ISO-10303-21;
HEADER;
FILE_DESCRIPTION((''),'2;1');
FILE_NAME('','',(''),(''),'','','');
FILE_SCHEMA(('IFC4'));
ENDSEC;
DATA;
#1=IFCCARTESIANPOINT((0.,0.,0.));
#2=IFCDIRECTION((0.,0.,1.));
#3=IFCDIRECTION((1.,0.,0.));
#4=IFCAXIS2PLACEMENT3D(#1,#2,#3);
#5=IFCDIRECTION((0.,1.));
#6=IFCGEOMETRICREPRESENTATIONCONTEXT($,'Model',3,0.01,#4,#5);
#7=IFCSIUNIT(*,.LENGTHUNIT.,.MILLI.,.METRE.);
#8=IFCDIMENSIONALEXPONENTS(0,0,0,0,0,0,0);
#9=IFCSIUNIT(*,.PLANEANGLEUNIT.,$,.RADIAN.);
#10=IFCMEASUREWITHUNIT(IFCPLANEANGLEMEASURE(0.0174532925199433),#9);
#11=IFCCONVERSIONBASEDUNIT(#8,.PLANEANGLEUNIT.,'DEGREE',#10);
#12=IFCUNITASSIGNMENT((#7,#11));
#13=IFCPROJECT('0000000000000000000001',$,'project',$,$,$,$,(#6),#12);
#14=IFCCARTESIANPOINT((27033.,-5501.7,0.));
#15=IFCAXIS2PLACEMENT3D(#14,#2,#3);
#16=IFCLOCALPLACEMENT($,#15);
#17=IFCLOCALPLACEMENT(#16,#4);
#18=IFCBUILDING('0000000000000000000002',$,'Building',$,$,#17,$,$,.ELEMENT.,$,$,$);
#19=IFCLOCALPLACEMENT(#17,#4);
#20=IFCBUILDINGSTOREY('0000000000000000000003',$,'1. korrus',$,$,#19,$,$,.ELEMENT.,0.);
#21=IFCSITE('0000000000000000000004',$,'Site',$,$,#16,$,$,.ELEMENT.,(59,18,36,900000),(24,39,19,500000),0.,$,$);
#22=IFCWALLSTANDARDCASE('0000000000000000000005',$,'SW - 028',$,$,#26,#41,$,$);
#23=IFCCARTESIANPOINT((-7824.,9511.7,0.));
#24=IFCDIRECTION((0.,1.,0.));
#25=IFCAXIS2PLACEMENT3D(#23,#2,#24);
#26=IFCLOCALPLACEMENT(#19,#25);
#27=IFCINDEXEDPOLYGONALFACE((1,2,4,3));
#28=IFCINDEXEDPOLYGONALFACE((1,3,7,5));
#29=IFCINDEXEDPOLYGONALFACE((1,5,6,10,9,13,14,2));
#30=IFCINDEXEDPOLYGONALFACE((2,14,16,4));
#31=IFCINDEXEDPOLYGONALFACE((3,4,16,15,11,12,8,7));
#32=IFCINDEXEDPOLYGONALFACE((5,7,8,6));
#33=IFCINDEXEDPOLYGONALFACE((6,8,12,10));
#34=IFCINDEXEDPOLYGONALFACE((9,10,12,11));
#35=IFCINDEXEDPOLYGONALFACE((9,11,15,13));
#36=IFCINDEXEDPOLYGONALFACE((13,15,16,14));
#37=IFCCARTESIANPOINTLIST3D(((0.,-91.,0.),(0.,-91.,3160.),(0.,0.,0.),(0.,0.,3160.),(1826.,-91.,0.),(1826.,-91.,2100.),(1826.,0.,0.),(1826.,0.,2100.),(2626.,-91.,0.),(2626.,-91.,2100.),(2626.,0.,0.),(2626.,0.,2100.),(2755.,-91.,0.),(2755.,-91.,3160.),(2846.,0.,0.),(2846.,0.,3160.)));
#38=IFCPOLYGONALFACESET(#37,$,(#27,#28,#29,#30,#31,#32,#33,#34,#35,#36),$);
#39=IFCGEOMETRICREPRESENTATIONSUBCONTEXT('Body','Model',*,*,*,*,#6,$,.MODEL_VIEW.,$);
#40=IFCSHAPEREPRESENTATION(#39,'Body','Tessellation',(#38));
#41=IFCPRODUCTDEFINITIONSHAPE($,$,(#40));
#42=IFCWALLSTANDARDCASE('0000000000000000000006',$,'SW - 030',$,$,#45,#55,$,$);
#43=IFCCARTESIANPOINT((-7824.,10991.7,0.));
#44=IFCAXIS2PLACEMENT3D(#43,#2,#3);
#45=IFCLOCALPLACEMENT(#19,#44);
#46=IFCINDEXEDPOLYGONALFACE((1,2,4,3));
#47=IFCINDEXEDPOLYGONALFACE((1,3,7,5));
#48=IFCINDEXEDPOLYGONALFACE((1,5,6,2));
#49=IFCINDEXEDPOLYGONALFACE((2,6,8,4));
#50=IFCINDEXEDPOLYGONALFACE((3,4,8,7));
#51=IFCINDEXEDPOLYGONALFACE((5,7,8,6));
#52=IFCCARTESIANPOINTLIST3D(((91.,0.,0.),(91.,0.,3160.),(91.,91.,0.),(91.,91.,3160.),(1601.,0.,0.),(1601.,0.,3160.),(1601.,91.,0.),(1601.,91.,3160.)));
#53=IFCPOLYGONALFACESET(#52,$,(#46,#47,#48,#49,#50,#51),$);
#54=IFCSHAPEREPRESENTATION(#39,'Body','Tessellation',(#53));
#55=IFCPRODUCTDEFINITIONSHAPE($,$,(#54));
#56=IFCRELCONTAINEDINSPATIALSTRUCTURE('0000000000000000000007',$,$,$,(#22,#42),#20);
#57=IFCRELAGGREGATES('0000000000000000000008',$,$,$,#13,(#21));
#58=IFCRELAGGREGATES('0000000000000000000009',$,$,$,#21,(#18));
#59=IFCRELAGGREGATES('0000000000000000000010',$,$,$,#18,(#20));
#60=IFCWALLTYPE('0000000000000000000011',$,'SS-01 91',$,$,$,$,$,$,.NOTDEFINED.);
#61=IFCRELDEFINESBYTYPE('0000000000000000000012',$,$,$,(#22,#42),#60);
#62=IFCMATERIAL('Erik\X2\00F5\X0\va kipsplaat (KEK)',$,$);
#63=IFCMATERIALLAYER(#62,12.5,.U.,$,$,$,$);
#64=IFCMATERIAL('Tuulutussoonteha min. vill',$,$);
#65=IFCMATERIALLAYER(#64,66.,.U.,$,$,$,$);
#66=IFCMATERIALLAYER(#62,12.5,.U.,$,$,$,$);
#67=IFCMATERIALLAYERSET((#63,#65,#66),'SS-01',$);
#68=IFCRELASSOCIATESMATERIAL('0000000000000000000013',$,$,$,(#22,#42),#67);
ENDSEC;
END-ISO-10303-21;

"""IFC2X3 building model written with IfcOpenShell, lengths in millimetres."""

from ifc_helpers import new_model, entity, si_unit, converted_unit, direction, frame, origin_with_axes, origin_2d_with_axis, place, context, subcontext, project, spatial, polyline, rectangle, outline, extrude, material, layer, layer_set, layer_usage, type_object, element, save


model = new_model("IFC2X3")

# Units and contexts
model_context = context("Model", 3, precision=0.01, world=origin_with_axes(), true_north=direction((0.0, 1.0)))
body_context = subcontext(model_context, "Body", "Model", "MODEL_VIEW")
ifc_project = project(units=[si_unit("LENGTHUNIT", "METRE", prefix="MILLI"), converted_unit("PLANEANGLEUNIT", "DEGREE", entity("IfcPlaneAngleMeasure", 0.0174532925199433), si_unit("PLANEANGLEUNIT", "RADIAN"), dimensions=[0, 0, 0, 0, 0, 0, 0])], contexts=[model_context])

# Site, building, storey
site_placement = place(None, frame((27033.0, -5501.7, 0.0), z_axis=(0.0, 0.0, 1.0), x_axis=(1.0, 0.0, 0.0)))
site = spatial("IfcSite", under=ifc_project, at=site_placement, Name="Site", CompositionType="ELEMENT", RefLatitude=(59, 18, 36, 900000), RefLongitude=(24, 39, 19, 500000), RefElevation=0.0)
building_placement = place(site_placement, origin_with_axes())
building = spatial("IfcBuilding", under=site, at=building_placement, Name="Building", CompositionType="ELEMENT")
storey_placement = place(building_placement, origin_with_axes())
storey = spatial("IfcBuildingStorey", under=building, at=storey_placement, Name="1. korrus", CompositionType="ELEMENT", Elevation=0.0)

# Wall, opening
ifc_material_1 = material(Name="Erikõva kipsplaat (KEK)")
ifc_layer_1 = layer(ifc_material_1, 12.5, ventilated="UNKNOWN")
ifc_material_2 = material(Name="Tuulutussoonteha min. vill")
ifc_layer_2 = layer(ifc_material_2, 66.0, ventilated="UNKNOWN")
ifc_layer_3 = layer(ifc_material_1, 12.5, ventilated="UNKNOWN")
ifc_layer_set_1 = layer_set([ifc_layer_1, ifc_layer_2, ifc_layer_3], Name="SS-01")
ifc_layer_usage_1 = layer_usage(ifc_layer_set_1, "AXIS2", "POSITIVE", -91.0)
wall_type_1 = type_object("IfcWallType", Name="SS-01 91", PredefinedType="NOTDEFINED")
wall_1_placement = place(storey_placement, frame((-7824.0, 9511.7, 0.0), z_axis=(0.0, 0.0, 1.0), x_axis=(0.0, 1.0, 0.0)))
wall_1 = element("IfcWallStandardCase", 1, at=wall_1_placement, inside=storey, type_object=wall_type_1, material=ifc_layer_usage_1, Name="SW - 028", context=body_context, shape_type="SweptSolid", body=[
    extrude(outline(polyline([(0.0, -91.0), (2755.0, -91.0), (2846.0, 0.0), (0.0, 0.0), (0.0, -91.0)])), origin_with_axes(), (0.0, 0.0, 1.0), 3160.0),
])
opening_1_placement = place(wall_1_placement, frame((2226.0, 0.0, 0.0), z_axis=(0.0, 0.0, 1.0), x_axis=(1.0, 0.0, 0.0)))
element("IfcOpeningElement", 2, at=opening_1_placement, cuts=wall_1, context=body_context, shape_type="SweptSolid", body=[
    extrude(rectangle(XDim=800.0, YDim=2100.0, at=origin_2d_with_axis()), frame((0.0, -91.0, 1050.0), z_axis=(0.0, -1.0, 0.0), x_axis=(-1.0, 0.0, 0.0)), (0.0, 0.0, -1.0), 273.0),
    extrude(rectangle(XDim=874.0, YDim=2137.0, at=origin_2d_with_axis()), frame((0.0, 0.0, 1068.5), z_axis=(0.0, 1.0, 0.0), x_axis=(-1.0, 0.0, 0.0)), (0.0, 0.0, 1.0), 91.0),
])

# Wall
ifc_layer_usage_2 = layer_usage(ifc_layer_set_1, "AXIS2", "NEGATIVE", 91.0)
wall_2_placement = place(storey_placement, frame((-7824.0, 10991.7, 0.0), z_axis=(0.0, 0.0, 1.0), x_axis=(1.0, 0.0, 0.0)))
element("IfcWallStandardCase", 3, at=wall_2_placement, inside=storey, type_object=wall_type_1, material=ifc_layer_usage_2, Name="SW - 030", context=body_context, shape_type="SweptSolid", body=[
    extrude(outline(polyline([(91.0, 0.0), (1601.0, 0.0), (1601.0, 91.0), (91.0, 91.0), (91.0, 0.0)])), origin_with_axes(), (0.0, 0.0, 1.0), 3160.0),
])

save(model, "model.ifc")
